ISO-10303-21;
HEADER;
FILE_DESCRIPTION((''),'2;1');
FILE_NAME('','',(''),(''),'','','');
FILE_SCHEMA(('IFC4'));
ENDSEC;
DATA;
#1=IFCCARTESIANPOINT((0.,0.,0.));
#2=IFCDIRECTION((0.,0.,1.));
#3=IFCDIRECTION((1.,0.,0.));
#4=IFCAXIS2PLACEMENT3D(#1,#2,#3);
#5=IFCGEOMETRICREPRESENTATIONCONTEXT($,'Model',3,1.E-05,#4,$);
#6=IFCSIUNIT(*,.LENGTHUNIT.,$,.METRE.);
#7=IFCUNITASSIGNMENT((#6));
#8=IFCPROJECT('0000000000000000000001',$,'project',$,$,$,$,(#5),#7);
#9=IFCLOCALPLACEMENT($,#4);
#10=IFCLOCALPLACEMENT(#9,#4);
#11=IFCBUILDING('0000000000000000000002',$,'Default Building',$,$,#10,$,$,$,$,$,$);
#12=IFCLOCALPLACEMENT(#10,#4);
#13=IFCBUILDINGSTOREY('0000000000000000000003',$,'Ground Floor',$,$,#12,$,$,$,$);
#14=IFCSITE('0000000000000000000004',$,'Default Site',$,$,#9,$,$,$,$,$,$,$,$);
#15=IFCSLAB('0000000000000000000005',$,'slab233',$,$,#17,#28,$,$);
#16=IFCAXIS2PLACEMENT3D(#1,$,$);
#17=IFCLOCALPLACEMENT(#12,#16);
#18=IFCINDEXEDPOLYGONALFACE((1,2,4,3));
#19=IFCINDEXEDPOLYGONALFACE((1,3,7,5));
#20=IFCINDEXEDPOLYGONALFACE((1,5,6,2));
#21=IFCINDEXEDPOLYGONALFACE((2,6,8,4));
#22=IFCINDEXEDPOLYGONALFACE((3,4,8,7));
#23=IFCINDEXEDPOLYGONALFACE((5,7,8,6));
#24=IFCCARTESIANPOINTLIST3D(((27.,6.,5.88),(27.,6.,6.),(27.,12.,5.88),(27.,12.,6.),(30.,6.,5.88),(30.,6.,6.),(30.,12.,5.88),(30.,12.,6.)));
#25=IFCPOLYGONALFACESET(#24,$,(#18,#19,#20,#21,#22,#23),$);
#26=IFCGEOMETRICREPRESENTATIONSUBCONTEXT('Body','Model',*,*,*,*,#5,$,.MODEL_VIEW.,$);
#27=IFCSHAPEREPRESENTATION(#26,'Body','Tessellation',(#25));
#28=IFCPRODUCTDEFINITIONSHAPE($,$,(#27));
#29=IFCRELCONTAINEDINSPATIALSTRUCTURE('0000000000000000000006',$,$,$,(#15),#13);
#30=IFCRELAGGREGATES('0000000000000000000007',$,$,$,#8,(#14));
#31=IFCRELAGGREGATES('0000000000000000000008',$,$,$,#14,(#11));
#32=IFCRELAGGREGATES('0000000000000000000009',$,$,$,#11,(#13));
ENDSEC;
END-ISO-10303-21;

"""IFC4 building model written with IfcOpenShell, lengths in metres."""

from ifc_helpers import new_model, si_unit, frame, origin_with_axes, place, context, subcontext, project, spatial, indexed_curve, outline, extrude, element, save


model = new_model("IFC4")

# Units and contexts
model_context = context("Model", 3, precision=1e-05, world=origin_with_axes())
body_context = subcontext(model_context, "Body", "Model", "MODEL_VIEW")
ifc_project = project(units=[si_unit("LENGTHUNIT", "METRE")], contexts=[model_context])

# Site, building, storey
site_placement = place(None, origin_with_axes())
site = spatial("IfcSite", under=ifc_project, at=site_placement, Name="Default Site")
building_placement = place(site_placement, origin_with_axes())
building = spatial("IfcBuilding", under=site, at=building_placement, Name="Default Building")
storey_placement = place(building_placement, origin_with_axes())
storey = spatial("IfcBuildingStorey", under=building, at=storey_placement, Name="Ground Floor")

# Slab
for number, where, z_axis, x_axis, name in (
    (1, (27.0, 6.0, 5.88), (0.0, 0.0, 1.0), (1.0, 0.0, 0.0), "slab233"),
):
    element("IfcSlab", number, at=place(storey_placement, frame(where, z_axis=z_axis, x_axis=x_axis)), inside=storey, Name=name, context=body_context, shape_type="SweptSolid", body=[
        extrude(outline(indexed_curve([(0.0, 0.0), (0.0, 6.0), (3.0, 6.0), (3.0, 0.0), (0.0, 0.0)], self_intersect=False)), origin_with_axes(), (0.0, 0.0, 1.0), 0.12),
    ])

save(model, "model.ifc")
